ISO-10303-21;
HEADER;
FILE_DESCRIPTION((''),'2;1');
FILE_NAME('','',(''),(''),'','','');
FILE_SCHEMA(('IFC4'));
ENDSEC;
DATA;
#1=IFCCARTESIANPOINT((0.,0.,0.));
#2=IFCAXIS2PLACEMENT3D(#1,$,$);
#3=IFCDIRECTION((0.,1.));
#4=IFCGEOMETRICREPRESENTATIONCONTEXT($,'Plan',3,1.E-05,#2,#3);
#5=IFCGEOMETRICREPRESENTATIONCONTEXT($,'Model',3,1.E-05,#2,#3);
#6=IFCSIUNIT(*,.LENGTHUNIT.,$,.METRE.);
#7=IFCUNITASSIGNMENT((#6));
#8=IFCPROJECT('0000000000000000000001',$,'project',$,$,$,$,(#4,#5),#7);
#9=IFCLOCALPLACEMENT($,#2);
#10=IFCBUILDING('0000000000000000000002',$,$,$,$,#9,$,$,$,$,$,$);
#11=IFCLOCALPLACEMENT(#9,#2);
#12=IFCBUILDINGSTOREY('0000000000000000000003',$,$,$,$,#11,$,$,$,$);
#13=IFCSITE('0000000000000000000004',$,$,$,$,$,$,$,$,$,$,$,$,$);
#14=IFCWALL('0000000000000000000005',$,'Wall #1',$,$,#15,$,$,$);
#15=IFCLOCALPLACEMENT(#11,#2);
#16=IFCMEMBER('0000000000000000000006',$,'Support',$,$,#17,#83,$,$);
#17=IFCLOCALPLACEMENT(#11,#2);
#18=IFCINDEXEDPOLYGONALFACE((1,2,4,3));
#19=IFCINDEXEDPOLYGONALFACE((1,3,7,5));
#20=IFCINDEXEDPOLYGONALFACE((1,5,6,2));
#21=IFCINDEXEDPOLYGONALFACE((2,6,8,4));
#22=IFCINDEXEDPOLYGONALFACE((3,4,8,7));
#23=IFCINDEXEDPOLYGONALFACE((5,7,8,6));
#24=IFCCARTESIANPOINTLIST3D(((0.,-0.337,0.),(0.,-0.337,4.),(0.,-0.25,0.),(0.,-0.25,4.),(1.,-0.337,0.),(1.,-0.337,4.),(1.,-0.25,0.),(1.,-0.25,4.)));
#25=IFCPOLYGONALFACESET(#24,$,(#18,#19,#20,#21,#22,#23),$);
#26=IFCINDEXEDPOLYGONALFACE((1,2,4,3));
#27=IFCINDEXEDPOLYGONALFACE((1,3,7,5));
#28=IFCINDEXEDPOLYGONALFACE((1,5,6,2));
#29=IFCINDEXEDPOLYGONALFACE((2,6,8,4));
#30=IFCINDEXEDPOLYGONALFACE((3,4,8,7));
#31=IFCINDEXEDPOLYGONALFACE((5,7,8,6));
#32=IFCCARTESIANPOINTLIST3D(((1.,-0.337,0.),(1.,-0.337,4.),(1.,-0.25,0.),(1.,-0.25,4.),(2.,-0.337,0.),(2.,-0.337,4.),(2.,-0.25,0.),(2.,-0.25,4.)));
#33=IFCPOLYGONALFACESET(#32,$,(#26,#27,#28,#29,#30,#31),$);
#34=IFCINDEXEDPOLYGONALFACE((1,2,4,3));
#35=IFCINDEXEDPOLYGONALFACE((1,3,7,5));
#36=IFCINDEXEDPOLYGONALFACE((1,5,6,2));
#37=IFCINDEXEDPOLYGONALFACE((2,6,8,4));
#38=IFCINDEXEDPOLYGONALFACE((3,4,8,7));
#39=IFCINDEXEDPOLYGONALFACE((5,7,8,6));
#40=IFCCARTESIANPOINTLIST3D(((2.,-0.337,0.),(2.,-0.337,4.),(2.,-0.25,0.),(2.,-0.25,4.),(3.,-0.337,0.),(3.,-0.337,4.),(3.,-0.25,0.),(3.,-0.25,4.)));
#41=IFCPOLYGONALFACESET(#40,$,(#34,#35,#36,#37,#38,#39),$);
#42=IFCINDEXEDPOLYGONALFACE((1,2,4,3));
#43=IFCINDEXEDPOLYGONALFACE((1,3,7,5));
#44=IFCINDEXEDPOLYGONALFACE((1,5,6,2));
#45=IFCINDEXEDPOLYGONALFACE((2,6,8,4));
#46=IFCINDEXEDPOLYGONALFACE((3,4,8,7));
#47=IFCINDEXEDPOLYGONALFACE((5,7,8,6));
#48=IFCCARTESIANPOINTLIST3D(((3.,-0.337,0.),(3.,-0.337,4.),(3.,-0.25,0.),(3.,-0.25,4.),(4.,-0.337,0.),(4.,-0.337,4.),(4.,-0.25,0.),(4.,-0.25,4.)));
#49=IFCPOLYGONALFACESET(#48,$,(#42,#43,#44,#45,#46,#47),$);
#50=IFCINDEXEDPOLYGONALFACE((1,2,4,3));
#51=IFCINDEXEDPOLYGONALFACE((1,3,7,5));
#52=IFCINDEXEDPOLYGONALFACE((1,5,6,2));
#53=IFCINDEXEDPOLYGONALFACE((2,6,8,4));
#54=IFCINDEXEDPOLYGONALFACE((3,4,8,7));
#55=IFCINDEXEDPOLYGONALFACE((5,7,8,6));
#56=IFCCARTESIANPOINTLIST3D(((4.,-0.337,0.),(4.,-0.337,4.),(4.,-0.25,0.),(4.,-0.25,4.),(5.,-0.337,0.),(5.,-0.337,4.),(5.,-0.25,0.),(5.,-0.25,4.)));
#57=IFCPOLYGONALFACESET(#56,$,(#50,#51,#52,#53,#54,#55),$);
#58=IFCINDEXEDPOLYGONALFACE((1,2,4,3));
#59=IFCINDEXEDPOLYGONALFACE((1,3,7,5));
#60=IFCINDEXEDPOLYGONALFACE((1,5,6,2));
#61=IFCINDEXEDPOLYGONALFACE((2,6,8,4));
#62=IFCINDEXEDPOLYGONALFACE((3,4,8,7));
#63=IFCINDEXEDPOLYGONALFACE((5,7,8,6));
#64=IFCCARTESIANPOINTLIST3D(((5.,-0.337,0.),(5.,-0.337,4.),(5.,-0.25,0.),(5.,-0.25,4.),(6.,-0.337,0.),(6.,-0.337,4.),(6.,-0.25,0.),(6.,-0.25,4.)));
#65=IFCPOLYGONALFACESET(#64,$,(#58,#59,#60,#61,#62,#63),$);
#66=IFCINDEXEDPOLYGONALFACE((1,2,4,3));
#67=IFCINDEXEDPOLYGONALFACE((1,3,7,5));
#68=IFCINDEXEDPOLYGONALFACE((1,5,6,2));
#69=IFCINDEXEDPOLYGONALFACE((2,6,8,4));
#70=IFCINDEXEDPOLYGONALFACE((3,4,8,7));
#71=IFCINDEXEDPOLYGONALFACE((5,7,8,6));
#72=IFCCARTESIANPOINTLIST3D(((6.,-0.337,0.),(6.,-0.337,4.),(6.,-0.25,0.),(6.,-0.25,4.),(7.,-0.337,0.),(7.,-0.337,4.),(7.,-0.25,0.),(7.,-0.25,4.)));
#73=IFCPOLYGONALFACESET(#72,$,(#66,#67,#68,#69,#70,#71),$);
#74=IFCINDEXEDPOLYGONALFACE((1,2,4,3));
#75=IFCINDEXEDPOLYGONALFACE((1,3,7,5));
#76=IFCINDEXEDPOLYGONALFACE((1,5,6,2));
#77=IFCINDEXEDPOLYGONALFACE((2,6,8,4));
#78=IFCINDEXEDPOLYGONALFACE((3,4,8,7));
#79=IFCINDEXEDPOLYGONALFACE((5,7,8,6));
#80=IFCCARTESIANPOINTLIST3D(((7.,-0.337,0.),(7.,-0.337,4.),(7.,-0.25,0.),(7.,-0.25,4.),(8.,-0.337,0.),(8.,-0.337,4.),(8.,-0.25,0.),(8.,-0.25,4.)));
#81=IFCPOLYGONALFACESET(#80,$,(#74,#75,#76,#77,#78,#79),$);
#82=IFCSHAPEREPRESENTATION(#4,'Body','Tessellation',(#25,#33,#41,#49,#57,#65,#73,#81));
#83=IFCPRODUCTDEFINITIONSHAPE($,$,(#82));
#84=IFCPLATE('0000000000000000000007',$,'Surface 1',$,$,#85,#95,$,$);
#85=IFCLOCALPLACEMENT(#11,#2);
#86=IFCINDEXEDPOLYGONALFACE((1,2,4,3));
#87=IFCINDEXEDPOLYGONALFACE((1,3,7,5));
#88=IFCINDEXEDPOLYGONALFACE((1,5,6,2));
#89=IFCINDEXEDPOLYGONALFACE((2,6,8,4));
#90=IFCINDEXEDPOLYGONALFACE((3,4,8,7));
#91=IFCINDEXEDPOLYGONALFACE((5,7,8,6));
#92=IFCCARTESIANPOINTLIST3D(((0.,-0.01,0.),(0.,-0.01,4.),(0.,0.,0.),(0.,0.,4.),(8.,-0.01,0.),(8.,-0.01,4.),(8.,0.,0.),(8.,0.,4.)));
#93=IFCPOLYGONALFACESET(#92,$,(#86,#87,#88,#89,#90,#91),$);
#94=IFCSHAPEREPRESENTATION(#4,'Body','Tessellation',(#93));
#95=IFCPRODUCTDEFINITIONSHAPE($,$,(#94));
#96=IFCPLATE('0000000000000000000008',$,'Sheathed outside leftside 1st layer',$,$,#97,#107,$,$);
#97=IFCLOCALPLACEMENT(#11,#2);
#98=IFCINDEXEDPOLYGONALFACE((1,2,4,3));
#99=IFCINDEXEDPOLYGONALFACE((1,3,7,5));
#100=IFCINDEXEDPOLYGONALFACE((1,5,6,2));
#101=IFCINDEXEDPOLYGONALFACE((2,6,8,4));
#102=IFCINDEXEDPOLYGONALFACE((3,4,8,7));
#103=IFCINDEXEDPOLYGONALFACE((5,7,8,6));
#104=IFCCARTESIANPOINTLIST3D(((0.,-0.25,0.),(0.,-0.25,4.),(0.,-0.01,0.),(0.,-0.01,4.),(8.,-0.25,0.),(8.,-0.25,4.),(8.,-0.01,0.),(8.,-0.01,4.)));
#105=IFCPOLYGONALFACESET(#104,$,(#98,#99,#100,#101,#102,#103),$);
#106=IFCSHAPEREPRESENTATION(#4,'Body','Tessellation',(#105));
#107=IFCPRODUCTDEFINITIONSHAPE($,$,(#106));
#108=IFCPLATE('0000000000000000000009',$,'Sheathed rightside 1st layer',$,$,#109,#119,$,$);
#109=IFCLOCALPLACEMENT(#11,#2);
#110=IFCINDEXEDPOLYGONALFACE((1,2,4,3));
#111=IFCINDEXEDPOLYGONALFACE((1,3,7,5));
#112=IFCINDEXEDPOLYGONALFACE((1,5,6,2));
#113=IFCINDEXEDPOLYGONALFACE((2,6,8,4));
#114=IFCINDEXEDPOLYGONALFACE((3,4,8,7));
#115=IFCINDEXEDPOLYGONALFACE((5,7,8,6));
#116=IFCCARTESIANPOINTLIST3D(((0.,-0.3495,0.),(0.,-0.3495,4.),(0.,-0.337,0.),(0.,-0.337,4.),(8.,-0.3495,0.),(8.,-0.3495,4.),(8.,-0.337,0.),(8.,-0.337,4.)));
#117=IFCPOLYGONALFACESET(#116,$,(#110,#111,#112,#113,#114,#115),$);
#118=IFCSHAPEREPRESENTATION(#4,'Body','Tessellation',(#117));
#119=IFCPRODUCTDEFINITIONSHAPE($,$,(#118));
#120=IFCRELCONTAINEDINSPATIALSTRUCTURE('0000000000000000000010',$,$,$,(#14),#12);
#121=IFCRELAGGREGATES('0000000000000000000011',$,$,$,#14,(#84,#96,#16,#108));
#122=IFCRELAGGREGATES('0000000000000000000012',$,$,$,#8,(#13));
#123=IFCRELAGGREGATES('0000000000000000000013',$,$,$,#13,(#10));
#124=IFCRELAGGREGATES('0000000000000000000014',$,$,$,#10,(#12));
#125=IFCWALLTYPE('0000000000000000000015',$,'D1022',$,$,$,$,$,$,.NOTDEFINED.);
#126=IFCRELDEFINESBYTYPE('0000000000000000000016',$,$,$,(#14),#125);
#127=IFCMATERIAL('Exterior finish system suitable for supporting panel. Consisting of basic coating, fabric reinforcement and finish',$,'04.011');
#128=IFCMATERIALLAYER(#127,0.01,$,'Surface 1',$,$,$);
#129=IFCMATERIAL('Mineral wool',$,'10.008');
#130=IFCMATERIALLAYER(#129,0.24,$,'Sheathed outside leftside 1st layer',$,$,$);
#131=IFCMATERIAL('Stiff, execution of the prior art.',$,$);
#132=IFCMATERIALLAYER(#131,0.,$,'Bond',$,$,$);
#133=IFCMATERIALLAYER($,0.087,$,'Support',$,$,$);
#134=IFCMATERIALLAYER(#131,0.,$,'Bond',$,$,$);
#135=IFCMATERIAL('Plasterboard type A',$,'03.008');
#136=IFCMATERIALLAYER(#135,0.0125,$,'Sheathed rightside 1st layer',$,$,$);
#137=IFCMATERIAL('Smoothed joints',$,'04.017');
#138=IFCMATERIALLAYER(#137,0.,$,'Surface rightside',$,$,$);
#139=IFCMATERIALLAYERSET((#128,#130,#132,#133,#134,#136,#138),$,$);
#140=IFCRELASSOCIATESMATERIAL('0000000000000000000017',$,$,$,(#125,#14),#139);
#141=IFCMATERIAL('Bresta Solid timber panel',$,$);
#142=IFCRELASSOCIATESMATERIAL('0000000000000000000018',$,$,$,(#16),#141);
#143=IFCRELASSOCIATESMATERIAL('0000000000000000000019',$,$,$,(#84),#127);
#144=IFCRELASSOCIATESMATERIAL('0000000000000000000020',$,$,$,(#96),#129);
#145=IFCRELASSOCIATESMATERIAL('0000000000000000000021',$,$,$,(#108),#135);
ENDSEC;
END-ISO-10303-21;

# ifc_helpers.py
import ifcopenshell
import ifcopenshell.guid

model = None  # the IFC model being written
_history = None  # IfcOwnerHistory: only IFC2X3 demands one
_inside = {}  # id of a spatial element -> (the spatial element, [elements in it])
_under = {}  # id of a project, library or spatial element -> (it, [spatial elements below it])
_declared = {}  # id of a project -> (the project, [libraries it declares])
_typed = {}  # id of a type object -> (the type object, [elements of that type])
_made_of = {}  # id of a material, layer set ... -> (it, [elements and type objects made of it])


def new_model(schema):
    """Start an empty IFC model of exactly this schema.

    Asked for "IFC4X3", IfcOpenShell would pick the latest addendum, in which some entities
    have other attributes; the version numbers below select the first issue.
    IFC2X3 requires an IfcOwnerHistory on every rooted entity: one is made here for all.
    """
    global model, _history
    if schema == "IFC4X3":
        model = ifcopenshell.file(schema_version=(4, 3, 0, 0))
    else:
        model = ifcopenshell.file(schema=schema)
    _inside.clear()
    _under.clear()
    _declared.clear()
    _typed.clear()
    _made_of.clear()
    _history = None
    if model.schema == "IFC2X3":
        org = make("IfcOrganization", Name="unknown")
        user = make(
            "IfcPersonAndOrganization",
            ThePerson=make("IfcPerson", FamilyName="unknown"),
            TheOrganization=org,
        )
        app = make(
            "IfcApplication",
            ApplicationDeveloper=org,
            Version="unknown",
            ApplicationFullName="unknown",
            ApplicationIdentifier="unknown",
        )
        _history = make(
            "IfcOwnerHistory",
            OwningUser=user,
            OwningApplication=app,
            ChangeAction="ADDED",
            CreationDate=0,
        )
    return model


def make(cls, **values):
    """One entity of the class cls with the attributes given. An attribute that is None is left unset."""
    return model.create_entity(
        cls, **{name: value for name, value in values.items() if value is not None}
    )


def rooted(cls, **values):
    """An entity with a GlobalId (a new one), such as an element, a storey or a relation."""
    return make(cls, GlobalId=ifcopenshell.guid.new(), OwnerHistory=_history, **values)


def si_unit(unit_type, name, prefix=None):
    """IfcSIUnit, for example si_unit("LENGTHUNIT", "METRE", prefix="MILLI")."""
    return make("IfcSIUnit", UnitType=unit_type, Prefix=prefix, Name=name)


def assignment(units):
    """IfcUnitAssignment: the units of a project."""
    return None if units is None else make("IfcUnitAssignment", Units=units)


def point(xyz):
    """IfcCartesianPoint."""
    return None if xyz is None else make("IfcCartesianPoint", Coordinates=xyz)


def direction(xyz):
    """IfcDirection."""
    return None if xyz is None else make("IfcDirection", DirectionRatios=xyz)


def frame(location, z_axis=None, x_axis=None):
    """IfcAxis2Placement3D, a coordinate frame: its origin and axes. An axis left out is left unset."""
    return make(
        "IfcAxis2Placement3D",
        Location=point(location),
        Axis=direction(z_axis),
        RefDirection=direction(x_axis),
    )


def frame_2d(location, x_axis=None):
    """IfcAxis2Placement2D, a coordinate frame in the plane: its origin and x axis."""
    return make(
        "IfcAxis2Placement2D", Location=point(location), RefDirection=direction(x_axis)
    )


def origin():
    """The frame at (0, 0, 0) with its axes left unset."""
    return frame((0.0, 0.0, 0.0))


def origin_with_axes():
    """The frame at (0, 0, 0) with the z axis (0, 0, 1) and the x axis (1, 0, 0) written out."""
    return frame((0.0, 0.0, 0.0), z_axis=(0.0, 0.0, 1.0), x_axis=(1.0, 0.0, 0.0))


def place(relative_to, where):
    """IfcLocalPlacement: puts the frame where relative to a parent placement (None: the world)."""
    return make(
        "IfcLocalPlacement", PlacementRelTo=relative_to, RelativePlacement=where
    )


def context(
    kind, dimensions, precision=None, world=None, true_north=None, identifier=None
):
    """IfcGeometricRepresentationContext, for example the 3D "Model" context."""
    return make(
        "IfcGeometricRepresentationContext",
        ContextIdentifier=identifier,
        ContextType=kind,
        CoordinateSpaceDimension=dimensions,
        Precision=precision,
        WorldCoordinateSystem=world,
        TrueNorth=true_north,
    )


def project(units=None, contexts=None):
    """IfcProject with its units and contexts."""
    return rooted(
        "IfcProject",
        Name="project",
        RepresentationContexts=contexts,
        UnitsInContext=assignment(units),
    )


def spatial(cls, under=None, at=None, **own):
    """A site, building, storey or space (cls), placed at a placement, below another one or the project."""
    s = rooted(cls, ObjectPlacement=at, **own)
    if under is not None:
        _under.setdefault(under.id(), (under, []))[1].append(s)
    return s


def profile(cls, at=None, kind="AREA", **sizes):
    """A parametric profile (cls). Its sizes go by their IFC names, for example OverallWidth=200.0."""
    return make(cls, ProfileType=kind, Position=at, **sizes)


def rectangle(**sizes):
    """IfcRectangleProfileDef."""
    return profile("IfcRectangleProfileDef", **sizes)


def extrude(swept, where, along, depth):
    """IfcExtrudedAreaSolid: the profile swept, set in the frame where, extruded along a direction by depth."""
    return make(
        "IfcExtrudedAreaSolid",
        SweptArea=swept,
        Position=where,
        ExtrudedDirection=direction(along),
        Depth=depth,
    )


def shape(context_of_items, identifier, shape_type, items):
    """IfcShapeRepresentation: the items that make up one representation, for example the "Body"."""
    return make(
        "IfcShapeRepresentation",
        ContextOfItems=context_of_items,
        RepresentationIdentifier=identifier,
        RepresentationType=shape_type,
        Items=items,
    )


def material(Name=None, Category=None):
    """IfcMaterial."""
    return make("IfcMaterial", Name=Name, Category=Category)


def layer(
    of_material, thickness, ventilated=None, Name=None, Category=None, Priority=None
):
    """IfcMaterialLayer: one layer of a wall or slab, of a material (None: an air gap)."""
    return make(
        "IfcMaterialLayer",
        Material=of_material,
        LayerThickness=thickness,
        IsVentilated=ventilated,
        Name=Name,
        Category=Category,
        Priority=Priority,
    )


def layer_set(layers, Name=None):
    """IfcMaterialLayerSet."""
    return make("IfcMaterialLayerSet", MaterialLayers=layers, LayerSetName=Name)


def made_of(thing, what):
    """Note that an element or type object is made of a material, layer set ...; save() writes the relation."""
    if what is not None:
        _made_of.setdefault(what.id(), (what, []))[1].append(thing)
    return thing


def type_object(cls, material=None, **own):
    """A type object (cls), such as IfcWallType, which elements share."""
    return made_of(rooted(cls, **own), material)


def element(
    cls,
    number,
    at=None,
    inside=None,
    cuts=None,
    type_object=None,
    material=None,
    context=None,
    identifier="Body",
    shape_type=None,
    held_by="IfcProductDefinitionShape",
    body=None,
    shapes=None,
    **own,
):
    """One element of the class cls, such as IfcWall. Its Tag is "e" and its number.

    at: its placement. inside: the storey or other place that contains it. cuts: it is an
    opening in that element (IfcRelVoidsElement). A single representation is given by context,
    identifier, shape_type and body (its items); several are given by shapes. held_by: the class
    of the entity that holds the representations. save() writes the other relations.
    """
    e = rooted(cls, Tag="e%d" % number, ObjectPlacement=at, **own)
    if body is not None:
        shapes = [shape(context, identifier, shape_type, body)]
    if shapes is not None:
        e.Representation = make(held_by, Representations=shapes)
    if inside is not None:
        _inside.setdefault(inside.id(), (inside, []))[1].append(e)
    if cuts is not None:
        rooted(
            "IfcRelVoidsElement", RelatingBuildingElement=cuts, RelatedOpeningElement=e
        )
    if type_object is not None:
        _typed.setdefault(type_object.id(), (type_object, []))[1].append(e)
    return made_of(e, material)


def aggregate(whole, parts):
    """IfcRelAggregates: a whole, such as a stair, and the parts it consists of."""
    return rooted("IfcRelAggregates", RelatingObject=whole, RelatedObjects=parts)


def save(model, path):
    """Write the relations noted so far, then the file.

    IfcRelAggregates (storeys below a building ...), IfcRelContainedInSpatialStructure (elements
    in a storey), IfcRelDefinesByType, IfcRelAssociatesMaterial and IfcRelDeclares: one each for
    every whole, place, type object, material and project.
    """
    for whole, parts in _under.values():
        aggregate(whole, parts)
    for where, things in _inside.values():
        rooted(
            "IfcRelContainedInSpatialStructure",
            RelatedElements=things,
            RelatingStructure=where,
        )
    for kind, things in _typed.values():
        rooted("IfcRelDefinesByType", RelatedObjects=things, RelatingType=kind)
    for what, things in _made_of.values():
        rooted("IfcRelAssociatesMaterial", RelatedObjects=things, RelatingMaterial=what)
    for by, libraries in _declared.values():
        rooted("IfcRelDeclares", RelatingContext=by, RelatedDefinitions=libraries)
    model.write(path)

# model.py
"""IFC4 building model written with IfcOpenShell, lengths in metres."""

from ifc_helpers import new_model, si_unit, direction, frame, frame_2d, origin, origin_with_axes, place, context, project, spatial, rectangle, extrude, material, layer, layer_set, type_object, element, aggregate, save


model = new_model("IFC4")

# Units and contexts
plan_context = context("Plan", 3, precision=1e-05, world=origin(), true_north=direction((0.0, 1.0)))
model_context = context("Model", 3, precision=1e-05, world=origin(), true_north=direction((0.0, 1.0)))
ifc_project = project(units=[si_unit("LENGTHUNIT", "METRE")], contexts=[plan_context, model_context])

# Site, building, storey
site = spatial("IfcSite", under=ifc_project)
building_placement = place(None, origin())
building = spatial("IfcBuilding", under=site, at=building_placement)
storey_placement = place(building_placement, origin())
storey = spatial("IfcBuildingStorey", under=building, at=storey_placement)

# Wall, member, plates
ifc_material_1 = material(Name="Exterior finish system suitable for supporting panel. Consisting of basic coating, fabric reinforcement and finish", Category="04.011")
ifc_layer_1 = layer(ifc_material_1, 0.01, Name="Surface 1")
ifc_material_2 = material(Name="Mineral wool", Category="10.008")
ifc_layer_2 = layer(ifc_material_2, 0.24, Name="Sheathed outside leftside 1st layer")
ifc_material_3 = material(Name="Stiff, execution of the prior art.")
ifc_layer_3 = layer(ifc_material_3, 0.0, Name="Bond")
ifc_layer_4 = layer(None, 0.087, Name="Support")
ifc_layer_5 = layer(ifc_material_3, 0.0, Name="Bond")
ifc_material_4 = material(Name="Plasterboard type A", Category="03.008")
ifc_layer_6 = layer(ifc_material_4, 0.0125, Name="Sheathed rightside 1st layer")
ifc_material_5 = material(Name="Smoothed joints", Category="04.017")
ifc_layer_7 = layer(ifc_material_5, 0.0, Name="Surface rightside")
ifc_layer_set = layer_set([ifc_layer_1, ifc_layer_2, ifc_layer_3, ifc_layer_4, ifc_layer_5, ifc_layer_6, ifc_layer_7])
wall_type = type_object("IfcWallType", Name="D1022", PredefinedType="NOTDEFINED", material=ifc_layer_set)
wall_placement = place(None, frame((0.0, 0.0, 0.0), z_axis=(0.0, -1.0, 0.0), x_axis=(1.0, 0.0, 0.0)))
wall = element("IfcWall", 1, at=wall_placement, inside=storey, type_object=wall_type, material=ifc_layer_set, Name="Wall #1")
ifc_material_6 = material(Name="Bresta Solid timber panel")
member_placement = place(wall_placement, origin())
member = element("IfcMember", 2, at=member_placement, material=ifc_material_6, Name="Support", context=plan_context, shape_type="SweptSolid", body=[
    extrude(rectangle(XDim=1.0, YDim=0.087, at=frame_2d((0.5, 0.0435), x_axis=(1.0, 0.0))), frame((0.0, 4.0, 0.25), z_axis=(0.0, -1.0, 0.0), x_axis=(1.0, 0.0, 0.0)), (0.0, 0.0, 1.0), 4.0),
    extrude(rectangle(XDim=1.0, YDim=0.087, at=frame_2d((0.5, 0.0435), x_axis=(1.0, 0.0))), frame((1.0, 4.0, 0.25), z_axis=(0.0, -1.0, 0.0), x_axis=(1.0, 0.0, 0.0)), (0.0, 0.0, 1.0), 4.0),
    extrude(rectangle(XDim=1.0, YDim=0.087, at=frame_2d((0.5, 0.0435), x_axis=(1.0, 0.0))), frame((2.0, 4.0, 0.25), z_axis=(0.0, -1.0, 0.0), x_axis=(1.0, 0.0, 0.0)), (0.0, 0.0, 1.0), 4.0),
    extrude(rectangle(XDim=1.0, YDim=0.087, at=frame_2d((0.5, 0.0435), x_axis=(1.0, 0.0))), frame((3.0, 4.0, 0.25), z_axis=(0.0, -1.0, 0.0), x_axis=(1.0, 0.0, 0.0)), (0.0, 0.0, 1.0), 4.0),
    extrude(rectangle(XDim=1.0, YDim=0.087, at=frame_2d((0.5, 0.0435), x_axis=(1.0, 0.0))), frame((4.0, 4.0, 0.25), z_axis=(0.0, -1.0, 0.0), x_axis=(1.0, 0.0, 0.0)), (0.0, 0.0, 1.0), 4.0),
    extrude(rectangle(XDim=1.0, YDim=0.087, at=frame_2d((0.5, 0.0435), x_axis=(1.0, 0.0))), frame((5.0, 4.0, 0.25), z_axis=(0.0, -1.0, 0.0), x_axis=(1.0, 0.0, 0.0)), (0.0, 0.0, 1.0), 4.0),
    extrude(rectangle(XDim=1.0, YDim=0.087, at=frame_2d((0.5, 0.0435), x_axis=(1.0, 0.0))), frame((6.0, 4.0, 0.25), z_axis=(0.0, -1.0, 0.0), x_axis=(1.0, 0.0, 0.0)), (0.0, 0.0, 1.0), 4.0),
    extrude(rectangle(XDim=1.0, YDim=0.087, at=frame_2d((0.5, 0.0435), x_axis=(1.0, 0.0))), frame((7.0, 4.0, 0.25), z_axis=(0.0, -1.0, 0.0), x_axis=(1.0, 0.0, 0.0)), (0.0, 0.0, 1.0), 4.0),
])
plate_1_placement = place(wall_placement, origin())
plate_1 = element("IfcPlate", 3, at=plate_1_placement, material=ifc_material_1, Name="Surface 1", context=plan_context, shape_type="SweptSolid", body=[
    extrude(rectangle(XDim=8.0, YDim=4.0, at=frame_2d((4.0, 2.0), x_axis=(1.0, 0.0))), origin_with_axes(), (0.0, 0.0, 1.0), 0.01),
])
plate_2_placement = place(wall_placement, origin())
plate_2 = element("IfcPlate", 4, at=plate_2_placement, material=ifc_material_2, Name="Sheathed outside leftside 1st layer", context=plan_context, shape_type="SweptSolid", body=[
    extrude(rectangle(XDim=8.0, YDim=4.0, at=frame_2d((4.0, 2.0), x_axis=(1.0, 0.0))), frame((0.0, 0.0, 0.01), z_axis=(0.0, 0.0, 1.0), x_axis=(1.0, 0.0, 0.0)), (0.0, 0.0, 1.0), 0.24),
])
plate_3_placement = place(wall_placement, origin())
plate_3 = element("IfcPlate", 5, at=plate_3_placement, material=ifc_material_4, Name="Sheathed rightside 1st layer", context=plan_context, shape_type="SweptSolid", body=[
    extrude(rectangle(XDim=8.0, YDim=4.0, at=frame_2d((4.0, 2.0), x_axis=(1.0, 0.0))), frame((0.0, 0.0, 0.337), z_axis=(0.0, 0.0, 1.0), x_axis=(1.0, 0.0, 0.0)), (0.0, 0.0, 1.0), 0.0125),
])
aggregate(wall, [plate_1, plate_2, member, plate_3])

save(model, "model.ifc")
